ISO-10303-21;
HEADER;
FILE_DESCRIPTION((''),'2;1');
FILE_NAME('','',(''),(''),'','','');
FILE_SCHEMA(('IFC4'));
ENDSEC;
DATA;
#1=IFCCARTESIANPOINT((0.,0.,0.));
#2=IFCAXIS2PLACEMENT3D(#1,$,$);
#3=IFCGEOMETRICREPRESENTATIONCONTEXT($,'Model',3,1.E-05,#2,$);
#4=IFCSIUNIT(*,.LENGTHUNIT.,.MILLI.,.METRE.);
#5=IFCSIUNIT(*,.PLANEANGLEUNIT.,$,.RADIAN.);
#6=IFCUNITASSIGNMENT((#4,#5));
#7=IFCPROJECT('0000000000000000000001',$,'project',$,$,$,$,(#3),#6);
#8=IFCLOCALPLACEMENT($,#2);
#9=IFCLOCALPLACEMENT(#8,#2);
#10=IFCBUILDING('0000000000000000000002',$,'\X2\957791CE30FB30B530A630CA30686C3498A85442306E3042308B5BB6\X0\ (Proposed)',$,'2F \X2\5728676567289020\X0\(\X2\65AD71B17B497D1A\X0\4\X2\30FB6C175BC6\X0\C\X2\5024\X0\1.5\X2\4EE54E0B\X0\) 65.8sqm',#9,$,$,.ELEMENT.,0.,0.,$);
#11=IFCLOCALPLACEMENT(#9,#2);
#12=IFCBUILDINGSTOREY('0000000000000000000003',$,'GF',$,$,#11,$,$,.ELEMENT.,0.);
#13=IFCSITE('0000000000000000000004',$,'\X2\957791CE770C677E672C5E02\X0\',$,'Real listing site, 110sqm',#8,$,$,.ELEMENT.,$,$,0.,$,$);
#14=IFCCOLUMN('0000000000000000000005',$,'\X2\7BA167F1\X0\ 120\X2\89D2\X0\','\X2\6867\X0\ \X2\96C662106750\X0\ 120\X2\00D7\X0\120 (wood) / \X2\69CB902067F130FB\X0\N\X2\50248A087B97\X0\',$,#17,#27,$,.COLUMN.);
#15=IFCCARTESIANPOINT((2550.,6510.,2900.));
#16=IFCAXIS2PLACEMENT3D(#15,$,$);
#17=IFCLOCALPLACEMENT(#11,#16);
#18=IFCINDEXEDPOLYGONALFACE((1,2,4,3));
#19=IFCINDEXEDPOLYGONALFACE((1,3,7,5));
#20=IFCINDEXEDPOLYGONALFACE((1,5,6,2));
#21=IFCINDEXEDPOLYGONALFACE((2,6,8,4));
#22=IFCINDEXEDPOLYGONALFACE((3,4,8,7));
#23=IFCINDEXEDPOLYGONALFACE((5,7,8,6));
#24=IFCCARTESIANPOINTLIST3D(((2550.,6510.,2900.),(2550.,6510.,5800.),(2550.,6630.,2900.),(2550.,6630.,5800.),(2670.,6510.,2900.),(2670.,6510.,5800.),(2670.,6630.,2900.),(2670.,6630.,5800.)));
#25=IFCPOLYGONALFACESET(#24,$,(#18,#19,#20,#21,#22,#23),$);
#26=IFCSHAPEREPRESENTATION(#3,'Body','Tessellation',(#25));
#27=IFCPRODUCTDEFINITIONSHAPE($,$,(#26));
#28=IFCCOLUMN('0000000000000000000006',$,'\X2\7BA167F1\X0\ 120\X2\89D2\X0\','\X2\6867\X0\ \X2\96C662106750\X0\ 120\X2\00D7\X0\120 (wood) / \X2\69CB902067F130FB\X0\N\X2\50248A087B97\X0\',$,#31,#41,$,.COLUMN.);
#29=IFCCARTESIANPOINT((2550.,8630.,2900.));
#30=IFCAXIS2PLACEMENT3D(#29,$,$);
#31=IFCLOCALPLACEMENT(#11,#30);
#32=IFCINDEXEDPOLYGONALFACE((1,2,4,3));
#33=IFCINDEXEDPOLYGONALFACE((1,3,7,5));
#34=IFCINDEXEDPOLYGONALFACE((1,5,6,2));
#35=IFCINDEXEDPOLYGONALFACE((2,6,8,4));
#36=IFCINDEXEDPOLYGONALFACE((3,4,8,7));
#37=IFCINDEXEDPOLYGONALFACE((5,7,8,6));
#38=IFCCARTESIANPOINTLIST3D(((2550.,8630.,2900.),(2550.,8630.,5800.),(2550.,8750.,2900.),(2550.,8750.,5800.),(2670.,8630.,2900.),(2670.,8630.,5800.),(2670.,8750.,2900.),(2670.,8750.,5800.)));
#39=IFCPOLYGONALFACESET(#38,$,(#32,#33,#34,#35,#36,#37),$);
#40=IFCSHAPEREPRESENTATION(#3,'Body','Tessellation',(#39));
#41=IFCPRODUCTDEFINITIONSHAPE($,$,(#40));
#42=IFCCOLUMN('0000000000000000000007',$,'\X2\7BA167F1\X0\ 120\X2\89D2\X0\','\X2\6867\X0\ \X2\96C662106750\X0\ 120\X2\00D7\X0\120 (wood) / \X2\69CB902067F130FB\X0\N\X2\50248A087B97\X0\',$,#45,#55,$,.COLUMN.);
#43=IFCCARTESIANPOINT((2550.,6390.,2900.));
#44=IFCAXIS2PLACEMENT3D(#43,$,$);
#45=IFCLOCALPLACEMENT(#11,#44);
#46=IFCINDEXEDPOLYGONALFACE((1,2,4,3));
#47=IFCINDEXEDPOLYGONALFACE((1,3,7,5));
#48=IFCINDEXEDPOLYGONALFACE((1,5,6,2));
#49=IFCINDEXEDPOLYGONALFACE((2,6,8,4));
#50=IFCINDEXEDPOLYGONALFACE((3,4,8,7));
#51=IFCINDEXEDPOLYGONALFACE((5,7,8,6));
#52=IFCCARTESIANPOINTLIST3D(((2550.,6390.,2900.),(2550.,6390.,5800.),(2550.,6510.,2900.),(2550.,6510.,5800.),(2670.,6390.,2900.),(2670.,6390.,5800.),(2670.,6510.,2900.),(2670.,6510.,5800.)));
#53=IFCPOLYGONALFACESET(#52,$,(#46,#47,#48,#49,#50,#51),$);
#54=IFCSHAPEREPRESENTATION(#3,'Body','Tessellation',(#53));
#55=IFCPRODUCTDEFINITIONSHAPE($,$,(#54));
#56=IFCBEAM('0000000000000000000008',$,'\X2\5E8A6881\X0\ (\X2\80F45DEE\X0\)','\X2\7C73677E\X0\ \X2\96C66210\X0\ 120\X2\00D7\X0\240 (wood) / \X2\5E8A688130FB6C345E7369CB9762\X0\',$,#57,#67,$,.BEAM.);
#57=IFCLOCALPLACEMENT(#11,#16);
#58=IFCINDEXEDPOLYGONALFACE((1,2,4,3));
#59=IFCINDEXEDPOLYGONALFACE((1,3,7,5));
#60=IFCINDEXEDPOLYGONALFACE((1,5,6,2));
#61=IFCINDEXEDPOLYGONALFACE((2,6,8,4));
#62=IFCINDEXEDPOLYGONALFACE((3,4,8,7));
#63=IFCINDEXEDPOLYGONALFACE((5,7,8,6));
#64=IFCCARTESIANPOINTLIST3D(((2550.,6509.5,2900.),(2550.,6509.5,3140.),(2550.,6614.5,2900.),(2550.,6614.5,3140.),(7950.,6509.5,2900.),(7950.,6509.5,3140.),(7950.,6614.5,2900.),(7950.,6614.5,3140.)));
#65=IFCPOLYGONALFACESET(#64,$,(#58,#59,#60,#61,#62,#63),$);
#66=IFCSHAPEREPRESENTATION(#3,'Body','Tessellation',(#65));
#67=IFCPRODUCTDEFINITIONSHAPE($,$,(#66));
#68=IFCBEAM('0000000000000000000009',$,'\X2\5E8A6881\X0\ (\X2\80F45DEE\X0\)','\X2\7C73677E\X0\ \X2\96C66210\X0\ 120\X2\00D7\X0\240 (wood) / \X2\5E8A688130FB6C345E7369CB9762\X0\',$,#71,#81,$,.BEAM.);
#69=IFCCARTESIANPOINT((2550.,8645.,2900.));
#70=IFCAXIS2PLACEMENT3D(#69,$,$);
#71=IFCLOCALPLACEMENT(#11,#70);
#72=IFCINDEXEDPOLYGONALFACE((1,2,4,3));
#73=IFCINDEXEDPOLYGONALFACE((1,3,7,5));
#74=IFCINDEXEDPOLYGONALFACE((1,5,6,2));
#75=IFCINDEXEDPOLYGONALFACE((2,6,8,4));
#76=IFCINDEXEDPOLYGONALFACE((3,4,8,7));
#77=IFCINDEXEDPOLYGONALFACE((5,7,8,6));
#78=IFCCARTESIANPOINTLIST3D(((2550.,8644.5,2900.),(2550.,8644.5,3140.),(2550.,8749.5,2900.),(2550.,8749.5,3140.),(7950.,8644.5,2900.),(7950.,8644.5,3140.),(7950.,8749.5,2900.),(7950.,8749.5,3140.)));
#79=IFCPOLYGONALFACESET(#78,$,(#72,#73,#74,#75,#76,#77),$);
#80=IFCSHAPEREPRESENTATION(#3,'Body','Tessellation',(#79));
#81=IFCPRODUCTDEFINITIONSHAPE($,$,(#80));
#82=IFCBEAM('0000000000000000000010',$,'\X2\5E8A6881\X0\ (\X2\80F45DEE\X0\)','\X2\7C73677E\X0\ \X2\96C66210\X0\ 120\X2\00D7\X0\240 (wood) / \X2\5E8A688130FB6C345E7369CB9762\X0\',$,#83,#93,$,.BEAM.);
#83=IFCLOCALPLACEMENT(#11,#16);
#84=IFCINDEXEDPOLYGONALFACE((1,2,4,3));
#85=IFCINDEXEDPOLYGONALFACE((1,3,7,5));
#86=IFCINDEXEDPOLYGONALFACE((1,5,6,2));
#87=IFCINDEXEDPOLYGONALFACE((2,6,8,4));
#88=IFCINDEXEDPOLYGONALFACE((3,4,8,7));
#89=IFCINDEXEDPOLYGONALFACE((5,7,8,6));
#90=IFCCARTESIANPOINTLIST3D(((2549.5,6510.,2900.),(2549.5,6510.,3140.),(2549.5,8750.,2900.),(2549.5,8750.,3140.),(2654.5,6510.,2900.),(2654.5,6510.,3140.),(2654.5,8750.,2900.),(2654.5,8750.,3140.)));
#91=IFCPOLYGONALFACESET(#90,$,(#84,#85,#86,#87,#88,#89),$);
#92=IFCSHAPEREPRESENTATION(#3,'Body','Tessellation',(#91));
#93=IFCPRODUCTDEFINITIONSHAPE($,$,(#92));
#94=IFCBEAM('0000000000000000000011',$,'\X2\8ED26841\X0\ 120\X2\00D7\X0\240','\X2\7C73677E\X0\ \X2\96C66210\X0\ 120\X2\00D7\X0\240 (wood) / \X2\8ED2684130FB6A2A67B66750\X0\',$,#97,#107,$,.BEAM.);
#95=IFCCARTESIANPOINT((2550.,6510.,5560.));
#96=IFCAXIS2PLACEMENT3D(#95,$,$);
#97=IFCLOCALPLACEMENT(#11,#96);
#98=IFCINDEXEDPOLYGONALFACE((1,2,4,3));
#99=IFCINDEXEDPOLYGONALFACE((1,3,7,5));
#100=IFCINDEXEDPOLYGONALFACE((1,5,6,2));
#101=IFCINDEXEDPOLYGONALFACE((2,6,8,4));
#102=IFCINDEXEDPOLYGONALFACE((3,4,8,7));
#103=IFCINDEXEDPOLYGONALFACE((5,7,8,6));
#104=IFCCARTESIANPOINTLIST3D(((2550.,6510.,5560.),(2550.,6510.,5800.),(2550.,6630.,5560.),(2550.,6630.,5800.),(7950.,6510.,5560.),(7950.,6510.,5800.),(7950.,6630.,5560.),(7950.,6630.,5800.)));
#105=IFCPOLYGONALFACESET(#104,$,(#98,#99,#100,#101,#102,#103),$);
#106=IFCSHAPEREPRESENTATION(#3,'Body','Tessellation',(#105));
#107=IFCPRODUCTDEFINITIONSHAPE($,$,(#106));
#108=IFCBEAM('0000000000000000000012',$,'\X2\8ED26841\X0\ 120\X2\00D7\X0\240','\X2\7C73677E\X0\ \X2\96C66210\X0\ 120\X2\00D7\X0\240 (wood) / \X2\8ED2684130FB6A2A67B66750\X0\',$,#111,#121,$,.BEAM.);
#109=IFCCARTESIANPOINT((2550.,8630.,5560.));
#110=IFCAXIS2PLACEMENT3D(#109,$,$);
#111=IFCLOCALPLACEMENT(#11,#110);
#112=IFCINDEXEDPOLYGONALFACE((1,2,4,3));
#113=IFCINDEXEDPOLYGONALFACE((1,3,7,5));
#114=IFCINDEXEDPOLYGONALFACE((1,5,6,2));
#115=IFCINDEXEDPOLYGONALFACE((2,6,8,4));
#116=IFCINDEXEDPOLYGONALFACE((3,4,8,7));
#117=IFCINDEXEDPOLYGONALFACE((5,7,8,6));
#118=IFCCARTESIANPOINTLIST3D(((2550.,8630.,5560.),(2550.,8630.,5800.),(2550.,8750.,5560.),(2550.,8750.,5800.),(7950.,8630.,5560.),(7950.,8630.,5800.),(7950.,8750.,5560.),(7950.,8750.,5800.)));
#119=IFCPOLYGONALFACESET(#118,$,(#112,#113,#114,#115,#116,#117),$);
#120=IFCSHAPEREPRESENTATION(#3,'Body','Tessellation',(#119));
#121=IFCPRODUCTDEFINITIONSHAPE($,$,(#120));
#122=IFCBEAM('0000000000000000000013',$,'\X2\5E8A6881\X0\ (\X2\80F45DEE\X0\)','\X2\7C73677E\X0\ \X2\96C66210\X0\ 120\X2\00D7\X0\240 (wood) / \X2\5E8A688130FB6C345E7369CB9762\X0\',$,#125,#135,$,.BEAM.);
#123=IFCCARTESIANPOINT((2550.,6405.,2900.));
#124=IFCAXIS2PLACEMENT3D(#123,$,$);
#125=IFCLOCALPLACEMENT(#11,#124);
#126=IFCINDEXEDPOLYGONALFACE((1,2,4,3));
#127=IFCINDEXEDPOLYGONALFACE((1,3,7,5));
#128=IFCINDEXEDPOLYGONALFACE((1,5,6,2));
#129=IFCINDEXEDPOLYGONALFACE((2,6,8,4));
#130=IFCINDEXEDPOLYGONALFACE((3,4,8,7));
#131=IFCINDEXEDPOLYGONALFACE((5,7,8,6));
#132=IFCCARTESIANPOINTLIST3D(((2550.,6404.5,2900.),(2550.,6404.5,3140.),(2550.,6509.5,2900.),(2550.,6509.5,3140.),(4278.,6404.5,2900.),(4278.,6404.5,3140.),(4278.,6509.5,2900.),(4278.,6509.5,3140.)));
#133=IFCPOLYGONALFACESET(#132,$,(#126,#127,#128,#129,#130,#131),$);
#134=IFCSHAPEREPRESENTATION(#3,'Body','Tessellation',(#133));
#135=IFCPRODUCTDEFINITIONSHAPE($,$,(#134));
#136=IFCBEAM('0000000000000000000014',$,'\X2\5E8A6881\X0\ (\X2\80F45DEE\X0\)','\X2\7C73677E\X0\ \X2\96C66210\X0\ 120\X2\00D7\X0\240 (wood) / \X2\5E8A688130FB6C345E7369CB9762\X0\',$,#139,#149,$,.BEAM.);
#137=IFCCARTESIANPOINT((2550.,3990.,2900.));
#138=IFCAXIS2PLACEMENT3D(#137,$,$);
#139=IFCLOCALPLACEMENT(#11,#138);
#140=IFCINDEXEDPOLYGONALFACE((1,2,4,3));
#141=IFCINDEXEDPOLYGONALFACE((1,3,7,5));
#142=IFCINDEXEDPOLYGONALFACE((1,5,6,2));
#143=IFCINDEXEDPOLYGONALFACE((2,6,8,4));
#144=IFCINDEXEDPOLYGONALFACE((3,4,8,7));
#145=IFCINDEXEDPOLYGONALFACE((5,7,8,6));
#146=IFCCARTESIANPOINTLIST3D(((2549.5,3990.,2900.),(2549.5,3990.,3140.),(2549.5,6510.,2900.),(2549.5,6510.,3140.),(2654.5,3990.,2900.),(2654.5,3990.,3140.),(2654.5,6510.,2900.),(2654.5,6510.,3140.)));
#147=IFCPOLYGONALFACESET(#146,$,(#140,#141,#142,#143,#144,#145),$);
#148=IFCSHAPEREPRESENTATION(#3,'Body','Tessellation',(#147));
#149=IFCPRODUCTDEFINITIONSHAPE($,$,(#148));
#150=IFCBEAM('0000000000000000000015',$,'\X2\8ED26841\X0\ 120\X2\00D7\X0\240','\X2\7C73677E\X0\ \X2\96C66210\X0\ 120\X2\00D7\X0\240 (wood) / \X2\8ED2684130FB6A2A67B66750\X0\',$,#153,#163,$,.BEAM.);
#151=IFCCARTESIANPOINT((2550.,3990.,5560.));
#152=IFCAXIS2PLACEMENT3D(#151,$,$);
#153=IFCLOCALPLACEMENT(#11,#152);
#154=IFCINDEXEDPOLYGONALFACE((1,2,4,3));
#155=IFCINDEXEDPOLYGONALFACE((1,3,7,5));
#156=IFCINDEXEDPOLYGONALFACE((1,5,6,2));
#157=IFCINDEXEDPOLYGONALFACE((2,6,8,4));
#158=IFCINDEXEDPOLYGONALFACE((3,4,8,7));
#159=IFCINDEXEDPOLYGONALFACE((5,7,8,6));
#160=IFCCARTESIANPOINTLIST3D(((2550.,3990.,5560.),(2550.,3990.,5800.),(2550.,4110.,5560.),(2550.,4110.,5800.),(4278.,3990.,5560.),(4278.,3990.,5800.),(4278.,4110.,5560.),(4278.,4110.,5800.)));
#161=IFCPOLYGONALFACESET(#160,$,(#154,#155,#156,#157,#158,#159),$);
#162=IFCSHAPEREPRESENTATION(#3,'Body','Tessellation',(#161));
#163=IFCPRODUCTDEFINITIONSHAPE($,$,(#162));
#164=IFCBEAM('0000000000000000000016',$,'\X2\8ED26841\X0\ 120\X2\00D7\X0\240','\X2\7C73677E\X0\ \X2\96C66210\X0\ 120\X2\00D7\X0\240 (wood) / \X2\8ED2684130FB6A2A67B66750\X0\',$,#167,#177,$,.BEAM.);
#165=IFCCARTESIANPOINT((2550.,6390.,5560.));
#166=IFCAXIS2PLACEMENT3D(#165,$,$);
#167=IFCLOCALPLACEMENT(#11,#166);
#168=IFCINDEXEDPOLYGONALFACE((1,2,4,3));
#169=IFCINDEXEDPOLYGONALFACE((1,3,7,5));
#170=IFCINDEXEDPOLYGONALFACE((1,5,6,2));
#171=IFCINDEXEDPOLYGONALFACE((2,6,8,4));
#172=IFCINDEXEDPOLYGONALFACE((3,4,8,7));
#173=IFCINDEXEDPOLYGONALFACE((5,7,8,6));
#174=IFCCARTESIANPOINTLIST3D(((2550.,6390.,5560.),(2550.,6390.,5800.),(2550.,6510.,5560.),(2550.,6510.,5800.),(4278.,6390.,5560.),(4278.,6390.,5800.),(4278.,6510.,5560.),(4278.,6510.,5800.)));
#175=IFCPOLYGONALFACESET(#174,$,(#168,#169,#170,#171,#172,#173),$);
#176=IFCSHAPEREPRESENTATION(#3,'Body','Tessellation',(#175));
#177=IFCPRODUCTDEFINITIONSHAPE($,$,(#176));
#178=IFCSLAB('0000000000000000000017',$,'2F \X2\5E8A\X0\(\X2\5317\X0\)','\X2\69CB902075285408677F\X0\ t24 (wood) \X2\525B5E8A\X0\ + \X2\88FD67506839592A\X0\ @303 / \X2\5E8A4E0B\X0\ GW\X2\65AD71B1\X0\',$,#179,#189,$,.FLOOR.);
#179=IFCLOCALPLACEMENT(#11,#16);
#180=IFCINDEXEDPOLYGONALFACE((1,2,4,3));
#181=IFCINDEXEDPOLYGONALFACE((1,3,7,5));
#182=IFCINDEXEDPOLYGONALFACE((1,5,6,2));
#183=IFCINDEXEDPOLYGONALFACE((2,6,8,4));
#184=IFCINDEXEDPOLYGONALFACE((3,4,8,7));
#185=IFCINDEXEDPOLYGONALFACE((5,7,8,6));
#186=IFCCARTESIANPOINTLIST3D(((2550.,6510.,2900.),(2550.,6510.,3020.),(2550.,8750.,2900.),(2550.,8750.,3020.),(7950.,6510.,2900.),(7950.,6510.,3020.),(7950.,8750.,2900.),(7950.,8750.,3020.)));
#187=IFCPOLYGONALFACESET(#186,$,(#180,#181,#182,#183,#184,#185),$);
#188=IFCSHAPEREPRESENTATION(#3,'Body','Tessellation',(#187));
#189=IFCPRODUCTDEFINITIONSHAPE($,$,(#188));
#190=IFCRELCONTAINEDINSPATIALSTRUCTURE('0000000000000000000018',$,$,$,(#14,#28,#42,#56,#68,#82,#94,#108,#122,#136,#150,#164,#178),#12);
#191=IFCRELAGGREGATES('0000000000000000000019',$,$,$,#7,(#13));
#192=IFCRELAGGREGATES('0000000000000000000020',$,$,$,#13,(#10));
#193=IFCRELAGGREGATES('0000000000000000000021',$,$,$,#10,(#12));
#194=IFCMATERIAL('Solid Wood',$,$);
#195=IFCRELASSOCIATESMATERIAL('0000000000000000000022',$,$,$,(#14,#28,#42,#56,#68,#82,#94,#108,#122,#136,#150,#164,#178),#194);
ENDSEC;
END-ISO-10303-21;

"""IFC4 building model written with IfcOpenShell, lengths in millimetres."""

from ifc_helpers import new_model, si_unit, frame, frame_2d, origin, place, context, project, spatial, rectangle, extrude, material, element, save


model = new_model("IFC4")

# Units and contexts
model_context = context("Model", 3, precision=1e-05, world=origin())
ifc_project = project(units=[si_unit("LENGTHUNIT", "METRE", prefix="MILLI"), si_unit("PLANEANGLEUNIT", "RADIAN")], contexts=[model_context])

# Site, building, storey
site_placement = place(None, origin())
site = spatial("IfcSite", under=ifc_project, at=site_placement, Name="長野県松本市", ObjectType="Real listing site, 110sqm", CompositionType="ELEMENT", RefElevation=0.0)
building_placement = place(site_placement, origin())
building = spatial("IfcBuilding", under=site, at=building_placement, Name="長野・サウナと水風呂のある家 (Proposed)", ObjectType="2F 在来木造(断熱等級4・気密C値1.5以下) 65.8sqm", CompositionType="ELEMENT", ElevationOfRefHeight=0.0, ElevationOfTerrain=0.0)
storey_placement = place(building_placement, origin())
storey = spatial("IfcBuildingStorey", under=building, at=storey_placement, Name="GF", CompositionType="ELEMENT", Elevation=0.0)

# Columns
ifc_material_1 = material(Name="Solid Wood")
column_1_placement = place(storey_placement, frame((2550.0, 6510.0, 2900.0)))
element("IfcColumn", 1, at=column_1_placement, inside=storey, material=ifc_material_1, Name="管柱 120角", Description="桧 集成材 120×120 (wood) / 構造柱・N値計算", PredefinedType="COLUMN", context=model_context, shape_type="SweptSolid", body=[
    extrude(rectangle(XDim=120.0, YDim=120.0, at=frame_2d((60.0, 60.0))), frame((2550.0, 6510.0, 2900.0)), (0.0, 0.0, 1.0), 2900.0),
])
column_2_placement = place(storey_placement, frame((2550.0, 8630.0, 2900.0)))
element("IfcColumn", 2, at=column_2_placement, inside=storey, material=ifc_material_1, Name="管柱 120角", Description="桧 集成材 120×120 (wood) / 構造柱・N値計算", PredefinedType="COLUMN", context=model_context, shape_type="SweptSolid", body=[
    extrude(rectangle(XDim=120.0, YDim=120.0, at=frame_2d((60.0, 60.0))), frame((2550.0, 8630.0, 2900.0)), (0.0, 0.0, 1.0), 2900.0),
])
column_3_placement = place(storey_placement, frame((2550.0, 6390.0, 2900.0)))
element("IfcColumn", 3, at=column_3_placement, inside=storey, material=ifc_material_1, Name="管柱 120角", Description="桧 集成材 120×120 (wood) / 構造柱・N値計算", PredefinedType="COLUMN", context=model_context, shape_type="SweptSolid", body=[
    extrude(rectangle(XDim=120.0, YDim=120.0, at=frame_2d((60.0, 60.0))), frame((2550.0, 6390.0, 2900.0)), (0.0, 0.0, 1.0), 2900.0),
])

# Beams
beam_1_placement = place(storey_placement, frame((2550.0, 6510.0, 2900.0)))
element("IfcBeam", 4, at=beam_1_placement, inside=storey, material=ifc_material_1, Name="床梁 (胴差)", Description="米松 集成 120×240 (wood) / 床梁・水平構面", PredefinedType="BEAM", context=model_context, shape_type="SweptSolid", body=[
    extrude(rectangle(XDim=5400.0, YDim=105.0, at=frame_2d((2700.0, 52.0))), frame((2550.0, 6510.0, 2900.0)), (0.0, 0.0, 1.0), 240.0),
])
beam_2_placement = place(storey_placement, frame((2550.0, 8645.0, 2900.0)))
element("IfcBeam", 5, at=beam_2_placement, inside=storey, material=ifc_material_1, Name="床梁 (胴差)", Description="米松 集成 120×240 (wood) / 床梁・水平構面", PredefinedType="BEAM", context=model_context, shape_type="SweptSolid", body=[
    extrude(rectangle(XDim=5400.0, YDim=105.0, at=frame_2d((2700.0, 52.0))), frame((2550.0, 8645.0, 2900.0)), (0.0, 0.0, 1.0), 240.0),
])
beam_3_placement = place(storey_placement, frame((2550.0, 6510.0, 2900.0)))
element("IfcBeam", 6, at=beam_3_placement, inside=storey, material=ifc_material_1, Name="床梁 (胴差)", Description="米松 集成 120×240 (wood) / 床梁・水平構面", PredefinedType="BEAM", context=model_context, shape_type="SweptSolid", body=[
    extrude(rectangle(XDim=105.0, YDim=2240.0, at=frame_2d((52.0, 1120.0))), frame((2550.0, 6510.0, 2900.0)), (0.0, 0.0, 1.0), 240.0),
])
beam_4_placement = place(storey_placement, frame((2550.0, 6510.0, 5560.0)))
element("IfcBeam", 7, at=beam_4_placement, inside=storey, material=ifc_material_1, Name="軒桁 120×240", Description="米松 集成 120×240 (wood) / 軒桁・横架材", PredefinedType="BEAM", context=model_context, shape_type="SweptSolid", body=[
    extrude(rectangle(XDim=5400.0, YDim=120.0, at=frame_2d((2700.0, 60.0))), frame((2550.0, 6510.0, 5560.0)), (0.0, 0.0, 1.0), 240.0),
])
beam_5_placement = place(storey_placement, frame((2550.0, 8630.0, 5560.0)))
element("IfcBeam", 8, at=beam_5_placement, inside=storey, material=ifc_material_1, Name="軒桁 120×240", Description="米松 集成 120×240 (wood) / 軒桁・横架材", PredefinedType="BEAM", context=model_context, shape_type="SweptSolid", body=[
    extrude(rectangle(XDim=5400.0, YDim=120.0, at=frame_2d((2700.0, 60.0))), frame((2550.0, 8630.0, 5560.0)), (0.0, 0.0, 1.0), 240.0),
])
beam_6_placement = place(storey_placement, frame((2550.0, 6405.0, 2900.0)))
element("IfcBeam", 9, at=beam_6_placement, inside=storey, material=ifc_material_1, Name="床梁 (胴差)", Description="米松 集成 120×240 (wood) / 床梁・水平構面", PredefinedType="BEAM", context=model_context, shape_type="SweptSolid", body=[
    extrude(rectangle(XDim=1728.0, YDim=105.0, at=frame_2d((864.0, 52.0))), frame((2550.0, 6405.0, 2900.0)), (0.0, 0.0, 1.0), 240.0),
])
beam_7_placement = place(storey_placement, frame((2550.0, 3990.0, 2900.0)))
element("IfcBeam", 10, at=beam_7_placement, inside=storey, material=ifc_material_1, Name="床梁 (胴差)", Description="米松 集成 120×240 (wood) / 床梁・水平構面", PredefinedType="BEAM", context=model_context, shape_type="SweptSolid", body=[
    extrude(rectangle(XDim=105.0, YDim=2520.0, at=frame_2d((52.0, 1260.0))), frame((2550.0, 3990.0, 2900.0)), (0.0, 0.0, 1.0), 240.0),
])
beam_8_placement = place(storey_placement, frame((2550.0, 3990.0, 5560.0)))
element("IfcBeam", 11, at=beam_8_placement, inside=storey, material=ifc_material_1, Name="軒桁 120×240", Description="米松 集成 120×240 (wood) / 軒桁・横架材", PredefinedType="BEAM", context=model_context, shape_type="SweptSolid", body=[
    extrude(rectangle(XDim=1728.0, YDim=120.0, at=frame_2d((864.0, 60.0))), frame((2550.0, 3990.0, 5560.0)), (0.0, 0.0, 1.0), 240.0),
])
beam_9_placement = place(storey_placement, frame((2550.0, 6390.0, 5560.0)))
element("IfcBeam", 12, at=beam_9_placement, inside=storey, material=ifc_material_1, Name="軒桁 120×240", Description="米松 集成 120×240 (wood) / 軒桁・横架材", PredefinedType="BEAM", context=model_context, shape_type="SweptSolid", body=[
    extrude(rectangle(XDim=1728.0, YDim=120.0, at=frame_2d((864.0, 60.0))), frame((2550.0, 6390.0, 5560.0)), (0.0, 0.0, 1.0), 240.0),
])

# Slab
slab_placement = place(storey_placement, frame((2550.0, 6510.0, 2900.0)))
element("IfcSlab", 13, at=slab_placement, inside=storey, material=ifc_material_1, Name="2F 床(北)", Description="構造用合板 t24 (wood) 剛床 + 製材根太 @303 / 床下 GW断熱", PredefinedType="FLOOR", context=model_context, shape_type="SweptSolid", body=[
    extrude(rectangle(XDim=5400.0, YDim=2240.0, at=frame_2d((2700.0, 1120.0))), frame((2550.0, 6510.0, 2900.0)), (0.0, 0.0, 1.0), 120.0),
])

save(model, "model.ifc")
